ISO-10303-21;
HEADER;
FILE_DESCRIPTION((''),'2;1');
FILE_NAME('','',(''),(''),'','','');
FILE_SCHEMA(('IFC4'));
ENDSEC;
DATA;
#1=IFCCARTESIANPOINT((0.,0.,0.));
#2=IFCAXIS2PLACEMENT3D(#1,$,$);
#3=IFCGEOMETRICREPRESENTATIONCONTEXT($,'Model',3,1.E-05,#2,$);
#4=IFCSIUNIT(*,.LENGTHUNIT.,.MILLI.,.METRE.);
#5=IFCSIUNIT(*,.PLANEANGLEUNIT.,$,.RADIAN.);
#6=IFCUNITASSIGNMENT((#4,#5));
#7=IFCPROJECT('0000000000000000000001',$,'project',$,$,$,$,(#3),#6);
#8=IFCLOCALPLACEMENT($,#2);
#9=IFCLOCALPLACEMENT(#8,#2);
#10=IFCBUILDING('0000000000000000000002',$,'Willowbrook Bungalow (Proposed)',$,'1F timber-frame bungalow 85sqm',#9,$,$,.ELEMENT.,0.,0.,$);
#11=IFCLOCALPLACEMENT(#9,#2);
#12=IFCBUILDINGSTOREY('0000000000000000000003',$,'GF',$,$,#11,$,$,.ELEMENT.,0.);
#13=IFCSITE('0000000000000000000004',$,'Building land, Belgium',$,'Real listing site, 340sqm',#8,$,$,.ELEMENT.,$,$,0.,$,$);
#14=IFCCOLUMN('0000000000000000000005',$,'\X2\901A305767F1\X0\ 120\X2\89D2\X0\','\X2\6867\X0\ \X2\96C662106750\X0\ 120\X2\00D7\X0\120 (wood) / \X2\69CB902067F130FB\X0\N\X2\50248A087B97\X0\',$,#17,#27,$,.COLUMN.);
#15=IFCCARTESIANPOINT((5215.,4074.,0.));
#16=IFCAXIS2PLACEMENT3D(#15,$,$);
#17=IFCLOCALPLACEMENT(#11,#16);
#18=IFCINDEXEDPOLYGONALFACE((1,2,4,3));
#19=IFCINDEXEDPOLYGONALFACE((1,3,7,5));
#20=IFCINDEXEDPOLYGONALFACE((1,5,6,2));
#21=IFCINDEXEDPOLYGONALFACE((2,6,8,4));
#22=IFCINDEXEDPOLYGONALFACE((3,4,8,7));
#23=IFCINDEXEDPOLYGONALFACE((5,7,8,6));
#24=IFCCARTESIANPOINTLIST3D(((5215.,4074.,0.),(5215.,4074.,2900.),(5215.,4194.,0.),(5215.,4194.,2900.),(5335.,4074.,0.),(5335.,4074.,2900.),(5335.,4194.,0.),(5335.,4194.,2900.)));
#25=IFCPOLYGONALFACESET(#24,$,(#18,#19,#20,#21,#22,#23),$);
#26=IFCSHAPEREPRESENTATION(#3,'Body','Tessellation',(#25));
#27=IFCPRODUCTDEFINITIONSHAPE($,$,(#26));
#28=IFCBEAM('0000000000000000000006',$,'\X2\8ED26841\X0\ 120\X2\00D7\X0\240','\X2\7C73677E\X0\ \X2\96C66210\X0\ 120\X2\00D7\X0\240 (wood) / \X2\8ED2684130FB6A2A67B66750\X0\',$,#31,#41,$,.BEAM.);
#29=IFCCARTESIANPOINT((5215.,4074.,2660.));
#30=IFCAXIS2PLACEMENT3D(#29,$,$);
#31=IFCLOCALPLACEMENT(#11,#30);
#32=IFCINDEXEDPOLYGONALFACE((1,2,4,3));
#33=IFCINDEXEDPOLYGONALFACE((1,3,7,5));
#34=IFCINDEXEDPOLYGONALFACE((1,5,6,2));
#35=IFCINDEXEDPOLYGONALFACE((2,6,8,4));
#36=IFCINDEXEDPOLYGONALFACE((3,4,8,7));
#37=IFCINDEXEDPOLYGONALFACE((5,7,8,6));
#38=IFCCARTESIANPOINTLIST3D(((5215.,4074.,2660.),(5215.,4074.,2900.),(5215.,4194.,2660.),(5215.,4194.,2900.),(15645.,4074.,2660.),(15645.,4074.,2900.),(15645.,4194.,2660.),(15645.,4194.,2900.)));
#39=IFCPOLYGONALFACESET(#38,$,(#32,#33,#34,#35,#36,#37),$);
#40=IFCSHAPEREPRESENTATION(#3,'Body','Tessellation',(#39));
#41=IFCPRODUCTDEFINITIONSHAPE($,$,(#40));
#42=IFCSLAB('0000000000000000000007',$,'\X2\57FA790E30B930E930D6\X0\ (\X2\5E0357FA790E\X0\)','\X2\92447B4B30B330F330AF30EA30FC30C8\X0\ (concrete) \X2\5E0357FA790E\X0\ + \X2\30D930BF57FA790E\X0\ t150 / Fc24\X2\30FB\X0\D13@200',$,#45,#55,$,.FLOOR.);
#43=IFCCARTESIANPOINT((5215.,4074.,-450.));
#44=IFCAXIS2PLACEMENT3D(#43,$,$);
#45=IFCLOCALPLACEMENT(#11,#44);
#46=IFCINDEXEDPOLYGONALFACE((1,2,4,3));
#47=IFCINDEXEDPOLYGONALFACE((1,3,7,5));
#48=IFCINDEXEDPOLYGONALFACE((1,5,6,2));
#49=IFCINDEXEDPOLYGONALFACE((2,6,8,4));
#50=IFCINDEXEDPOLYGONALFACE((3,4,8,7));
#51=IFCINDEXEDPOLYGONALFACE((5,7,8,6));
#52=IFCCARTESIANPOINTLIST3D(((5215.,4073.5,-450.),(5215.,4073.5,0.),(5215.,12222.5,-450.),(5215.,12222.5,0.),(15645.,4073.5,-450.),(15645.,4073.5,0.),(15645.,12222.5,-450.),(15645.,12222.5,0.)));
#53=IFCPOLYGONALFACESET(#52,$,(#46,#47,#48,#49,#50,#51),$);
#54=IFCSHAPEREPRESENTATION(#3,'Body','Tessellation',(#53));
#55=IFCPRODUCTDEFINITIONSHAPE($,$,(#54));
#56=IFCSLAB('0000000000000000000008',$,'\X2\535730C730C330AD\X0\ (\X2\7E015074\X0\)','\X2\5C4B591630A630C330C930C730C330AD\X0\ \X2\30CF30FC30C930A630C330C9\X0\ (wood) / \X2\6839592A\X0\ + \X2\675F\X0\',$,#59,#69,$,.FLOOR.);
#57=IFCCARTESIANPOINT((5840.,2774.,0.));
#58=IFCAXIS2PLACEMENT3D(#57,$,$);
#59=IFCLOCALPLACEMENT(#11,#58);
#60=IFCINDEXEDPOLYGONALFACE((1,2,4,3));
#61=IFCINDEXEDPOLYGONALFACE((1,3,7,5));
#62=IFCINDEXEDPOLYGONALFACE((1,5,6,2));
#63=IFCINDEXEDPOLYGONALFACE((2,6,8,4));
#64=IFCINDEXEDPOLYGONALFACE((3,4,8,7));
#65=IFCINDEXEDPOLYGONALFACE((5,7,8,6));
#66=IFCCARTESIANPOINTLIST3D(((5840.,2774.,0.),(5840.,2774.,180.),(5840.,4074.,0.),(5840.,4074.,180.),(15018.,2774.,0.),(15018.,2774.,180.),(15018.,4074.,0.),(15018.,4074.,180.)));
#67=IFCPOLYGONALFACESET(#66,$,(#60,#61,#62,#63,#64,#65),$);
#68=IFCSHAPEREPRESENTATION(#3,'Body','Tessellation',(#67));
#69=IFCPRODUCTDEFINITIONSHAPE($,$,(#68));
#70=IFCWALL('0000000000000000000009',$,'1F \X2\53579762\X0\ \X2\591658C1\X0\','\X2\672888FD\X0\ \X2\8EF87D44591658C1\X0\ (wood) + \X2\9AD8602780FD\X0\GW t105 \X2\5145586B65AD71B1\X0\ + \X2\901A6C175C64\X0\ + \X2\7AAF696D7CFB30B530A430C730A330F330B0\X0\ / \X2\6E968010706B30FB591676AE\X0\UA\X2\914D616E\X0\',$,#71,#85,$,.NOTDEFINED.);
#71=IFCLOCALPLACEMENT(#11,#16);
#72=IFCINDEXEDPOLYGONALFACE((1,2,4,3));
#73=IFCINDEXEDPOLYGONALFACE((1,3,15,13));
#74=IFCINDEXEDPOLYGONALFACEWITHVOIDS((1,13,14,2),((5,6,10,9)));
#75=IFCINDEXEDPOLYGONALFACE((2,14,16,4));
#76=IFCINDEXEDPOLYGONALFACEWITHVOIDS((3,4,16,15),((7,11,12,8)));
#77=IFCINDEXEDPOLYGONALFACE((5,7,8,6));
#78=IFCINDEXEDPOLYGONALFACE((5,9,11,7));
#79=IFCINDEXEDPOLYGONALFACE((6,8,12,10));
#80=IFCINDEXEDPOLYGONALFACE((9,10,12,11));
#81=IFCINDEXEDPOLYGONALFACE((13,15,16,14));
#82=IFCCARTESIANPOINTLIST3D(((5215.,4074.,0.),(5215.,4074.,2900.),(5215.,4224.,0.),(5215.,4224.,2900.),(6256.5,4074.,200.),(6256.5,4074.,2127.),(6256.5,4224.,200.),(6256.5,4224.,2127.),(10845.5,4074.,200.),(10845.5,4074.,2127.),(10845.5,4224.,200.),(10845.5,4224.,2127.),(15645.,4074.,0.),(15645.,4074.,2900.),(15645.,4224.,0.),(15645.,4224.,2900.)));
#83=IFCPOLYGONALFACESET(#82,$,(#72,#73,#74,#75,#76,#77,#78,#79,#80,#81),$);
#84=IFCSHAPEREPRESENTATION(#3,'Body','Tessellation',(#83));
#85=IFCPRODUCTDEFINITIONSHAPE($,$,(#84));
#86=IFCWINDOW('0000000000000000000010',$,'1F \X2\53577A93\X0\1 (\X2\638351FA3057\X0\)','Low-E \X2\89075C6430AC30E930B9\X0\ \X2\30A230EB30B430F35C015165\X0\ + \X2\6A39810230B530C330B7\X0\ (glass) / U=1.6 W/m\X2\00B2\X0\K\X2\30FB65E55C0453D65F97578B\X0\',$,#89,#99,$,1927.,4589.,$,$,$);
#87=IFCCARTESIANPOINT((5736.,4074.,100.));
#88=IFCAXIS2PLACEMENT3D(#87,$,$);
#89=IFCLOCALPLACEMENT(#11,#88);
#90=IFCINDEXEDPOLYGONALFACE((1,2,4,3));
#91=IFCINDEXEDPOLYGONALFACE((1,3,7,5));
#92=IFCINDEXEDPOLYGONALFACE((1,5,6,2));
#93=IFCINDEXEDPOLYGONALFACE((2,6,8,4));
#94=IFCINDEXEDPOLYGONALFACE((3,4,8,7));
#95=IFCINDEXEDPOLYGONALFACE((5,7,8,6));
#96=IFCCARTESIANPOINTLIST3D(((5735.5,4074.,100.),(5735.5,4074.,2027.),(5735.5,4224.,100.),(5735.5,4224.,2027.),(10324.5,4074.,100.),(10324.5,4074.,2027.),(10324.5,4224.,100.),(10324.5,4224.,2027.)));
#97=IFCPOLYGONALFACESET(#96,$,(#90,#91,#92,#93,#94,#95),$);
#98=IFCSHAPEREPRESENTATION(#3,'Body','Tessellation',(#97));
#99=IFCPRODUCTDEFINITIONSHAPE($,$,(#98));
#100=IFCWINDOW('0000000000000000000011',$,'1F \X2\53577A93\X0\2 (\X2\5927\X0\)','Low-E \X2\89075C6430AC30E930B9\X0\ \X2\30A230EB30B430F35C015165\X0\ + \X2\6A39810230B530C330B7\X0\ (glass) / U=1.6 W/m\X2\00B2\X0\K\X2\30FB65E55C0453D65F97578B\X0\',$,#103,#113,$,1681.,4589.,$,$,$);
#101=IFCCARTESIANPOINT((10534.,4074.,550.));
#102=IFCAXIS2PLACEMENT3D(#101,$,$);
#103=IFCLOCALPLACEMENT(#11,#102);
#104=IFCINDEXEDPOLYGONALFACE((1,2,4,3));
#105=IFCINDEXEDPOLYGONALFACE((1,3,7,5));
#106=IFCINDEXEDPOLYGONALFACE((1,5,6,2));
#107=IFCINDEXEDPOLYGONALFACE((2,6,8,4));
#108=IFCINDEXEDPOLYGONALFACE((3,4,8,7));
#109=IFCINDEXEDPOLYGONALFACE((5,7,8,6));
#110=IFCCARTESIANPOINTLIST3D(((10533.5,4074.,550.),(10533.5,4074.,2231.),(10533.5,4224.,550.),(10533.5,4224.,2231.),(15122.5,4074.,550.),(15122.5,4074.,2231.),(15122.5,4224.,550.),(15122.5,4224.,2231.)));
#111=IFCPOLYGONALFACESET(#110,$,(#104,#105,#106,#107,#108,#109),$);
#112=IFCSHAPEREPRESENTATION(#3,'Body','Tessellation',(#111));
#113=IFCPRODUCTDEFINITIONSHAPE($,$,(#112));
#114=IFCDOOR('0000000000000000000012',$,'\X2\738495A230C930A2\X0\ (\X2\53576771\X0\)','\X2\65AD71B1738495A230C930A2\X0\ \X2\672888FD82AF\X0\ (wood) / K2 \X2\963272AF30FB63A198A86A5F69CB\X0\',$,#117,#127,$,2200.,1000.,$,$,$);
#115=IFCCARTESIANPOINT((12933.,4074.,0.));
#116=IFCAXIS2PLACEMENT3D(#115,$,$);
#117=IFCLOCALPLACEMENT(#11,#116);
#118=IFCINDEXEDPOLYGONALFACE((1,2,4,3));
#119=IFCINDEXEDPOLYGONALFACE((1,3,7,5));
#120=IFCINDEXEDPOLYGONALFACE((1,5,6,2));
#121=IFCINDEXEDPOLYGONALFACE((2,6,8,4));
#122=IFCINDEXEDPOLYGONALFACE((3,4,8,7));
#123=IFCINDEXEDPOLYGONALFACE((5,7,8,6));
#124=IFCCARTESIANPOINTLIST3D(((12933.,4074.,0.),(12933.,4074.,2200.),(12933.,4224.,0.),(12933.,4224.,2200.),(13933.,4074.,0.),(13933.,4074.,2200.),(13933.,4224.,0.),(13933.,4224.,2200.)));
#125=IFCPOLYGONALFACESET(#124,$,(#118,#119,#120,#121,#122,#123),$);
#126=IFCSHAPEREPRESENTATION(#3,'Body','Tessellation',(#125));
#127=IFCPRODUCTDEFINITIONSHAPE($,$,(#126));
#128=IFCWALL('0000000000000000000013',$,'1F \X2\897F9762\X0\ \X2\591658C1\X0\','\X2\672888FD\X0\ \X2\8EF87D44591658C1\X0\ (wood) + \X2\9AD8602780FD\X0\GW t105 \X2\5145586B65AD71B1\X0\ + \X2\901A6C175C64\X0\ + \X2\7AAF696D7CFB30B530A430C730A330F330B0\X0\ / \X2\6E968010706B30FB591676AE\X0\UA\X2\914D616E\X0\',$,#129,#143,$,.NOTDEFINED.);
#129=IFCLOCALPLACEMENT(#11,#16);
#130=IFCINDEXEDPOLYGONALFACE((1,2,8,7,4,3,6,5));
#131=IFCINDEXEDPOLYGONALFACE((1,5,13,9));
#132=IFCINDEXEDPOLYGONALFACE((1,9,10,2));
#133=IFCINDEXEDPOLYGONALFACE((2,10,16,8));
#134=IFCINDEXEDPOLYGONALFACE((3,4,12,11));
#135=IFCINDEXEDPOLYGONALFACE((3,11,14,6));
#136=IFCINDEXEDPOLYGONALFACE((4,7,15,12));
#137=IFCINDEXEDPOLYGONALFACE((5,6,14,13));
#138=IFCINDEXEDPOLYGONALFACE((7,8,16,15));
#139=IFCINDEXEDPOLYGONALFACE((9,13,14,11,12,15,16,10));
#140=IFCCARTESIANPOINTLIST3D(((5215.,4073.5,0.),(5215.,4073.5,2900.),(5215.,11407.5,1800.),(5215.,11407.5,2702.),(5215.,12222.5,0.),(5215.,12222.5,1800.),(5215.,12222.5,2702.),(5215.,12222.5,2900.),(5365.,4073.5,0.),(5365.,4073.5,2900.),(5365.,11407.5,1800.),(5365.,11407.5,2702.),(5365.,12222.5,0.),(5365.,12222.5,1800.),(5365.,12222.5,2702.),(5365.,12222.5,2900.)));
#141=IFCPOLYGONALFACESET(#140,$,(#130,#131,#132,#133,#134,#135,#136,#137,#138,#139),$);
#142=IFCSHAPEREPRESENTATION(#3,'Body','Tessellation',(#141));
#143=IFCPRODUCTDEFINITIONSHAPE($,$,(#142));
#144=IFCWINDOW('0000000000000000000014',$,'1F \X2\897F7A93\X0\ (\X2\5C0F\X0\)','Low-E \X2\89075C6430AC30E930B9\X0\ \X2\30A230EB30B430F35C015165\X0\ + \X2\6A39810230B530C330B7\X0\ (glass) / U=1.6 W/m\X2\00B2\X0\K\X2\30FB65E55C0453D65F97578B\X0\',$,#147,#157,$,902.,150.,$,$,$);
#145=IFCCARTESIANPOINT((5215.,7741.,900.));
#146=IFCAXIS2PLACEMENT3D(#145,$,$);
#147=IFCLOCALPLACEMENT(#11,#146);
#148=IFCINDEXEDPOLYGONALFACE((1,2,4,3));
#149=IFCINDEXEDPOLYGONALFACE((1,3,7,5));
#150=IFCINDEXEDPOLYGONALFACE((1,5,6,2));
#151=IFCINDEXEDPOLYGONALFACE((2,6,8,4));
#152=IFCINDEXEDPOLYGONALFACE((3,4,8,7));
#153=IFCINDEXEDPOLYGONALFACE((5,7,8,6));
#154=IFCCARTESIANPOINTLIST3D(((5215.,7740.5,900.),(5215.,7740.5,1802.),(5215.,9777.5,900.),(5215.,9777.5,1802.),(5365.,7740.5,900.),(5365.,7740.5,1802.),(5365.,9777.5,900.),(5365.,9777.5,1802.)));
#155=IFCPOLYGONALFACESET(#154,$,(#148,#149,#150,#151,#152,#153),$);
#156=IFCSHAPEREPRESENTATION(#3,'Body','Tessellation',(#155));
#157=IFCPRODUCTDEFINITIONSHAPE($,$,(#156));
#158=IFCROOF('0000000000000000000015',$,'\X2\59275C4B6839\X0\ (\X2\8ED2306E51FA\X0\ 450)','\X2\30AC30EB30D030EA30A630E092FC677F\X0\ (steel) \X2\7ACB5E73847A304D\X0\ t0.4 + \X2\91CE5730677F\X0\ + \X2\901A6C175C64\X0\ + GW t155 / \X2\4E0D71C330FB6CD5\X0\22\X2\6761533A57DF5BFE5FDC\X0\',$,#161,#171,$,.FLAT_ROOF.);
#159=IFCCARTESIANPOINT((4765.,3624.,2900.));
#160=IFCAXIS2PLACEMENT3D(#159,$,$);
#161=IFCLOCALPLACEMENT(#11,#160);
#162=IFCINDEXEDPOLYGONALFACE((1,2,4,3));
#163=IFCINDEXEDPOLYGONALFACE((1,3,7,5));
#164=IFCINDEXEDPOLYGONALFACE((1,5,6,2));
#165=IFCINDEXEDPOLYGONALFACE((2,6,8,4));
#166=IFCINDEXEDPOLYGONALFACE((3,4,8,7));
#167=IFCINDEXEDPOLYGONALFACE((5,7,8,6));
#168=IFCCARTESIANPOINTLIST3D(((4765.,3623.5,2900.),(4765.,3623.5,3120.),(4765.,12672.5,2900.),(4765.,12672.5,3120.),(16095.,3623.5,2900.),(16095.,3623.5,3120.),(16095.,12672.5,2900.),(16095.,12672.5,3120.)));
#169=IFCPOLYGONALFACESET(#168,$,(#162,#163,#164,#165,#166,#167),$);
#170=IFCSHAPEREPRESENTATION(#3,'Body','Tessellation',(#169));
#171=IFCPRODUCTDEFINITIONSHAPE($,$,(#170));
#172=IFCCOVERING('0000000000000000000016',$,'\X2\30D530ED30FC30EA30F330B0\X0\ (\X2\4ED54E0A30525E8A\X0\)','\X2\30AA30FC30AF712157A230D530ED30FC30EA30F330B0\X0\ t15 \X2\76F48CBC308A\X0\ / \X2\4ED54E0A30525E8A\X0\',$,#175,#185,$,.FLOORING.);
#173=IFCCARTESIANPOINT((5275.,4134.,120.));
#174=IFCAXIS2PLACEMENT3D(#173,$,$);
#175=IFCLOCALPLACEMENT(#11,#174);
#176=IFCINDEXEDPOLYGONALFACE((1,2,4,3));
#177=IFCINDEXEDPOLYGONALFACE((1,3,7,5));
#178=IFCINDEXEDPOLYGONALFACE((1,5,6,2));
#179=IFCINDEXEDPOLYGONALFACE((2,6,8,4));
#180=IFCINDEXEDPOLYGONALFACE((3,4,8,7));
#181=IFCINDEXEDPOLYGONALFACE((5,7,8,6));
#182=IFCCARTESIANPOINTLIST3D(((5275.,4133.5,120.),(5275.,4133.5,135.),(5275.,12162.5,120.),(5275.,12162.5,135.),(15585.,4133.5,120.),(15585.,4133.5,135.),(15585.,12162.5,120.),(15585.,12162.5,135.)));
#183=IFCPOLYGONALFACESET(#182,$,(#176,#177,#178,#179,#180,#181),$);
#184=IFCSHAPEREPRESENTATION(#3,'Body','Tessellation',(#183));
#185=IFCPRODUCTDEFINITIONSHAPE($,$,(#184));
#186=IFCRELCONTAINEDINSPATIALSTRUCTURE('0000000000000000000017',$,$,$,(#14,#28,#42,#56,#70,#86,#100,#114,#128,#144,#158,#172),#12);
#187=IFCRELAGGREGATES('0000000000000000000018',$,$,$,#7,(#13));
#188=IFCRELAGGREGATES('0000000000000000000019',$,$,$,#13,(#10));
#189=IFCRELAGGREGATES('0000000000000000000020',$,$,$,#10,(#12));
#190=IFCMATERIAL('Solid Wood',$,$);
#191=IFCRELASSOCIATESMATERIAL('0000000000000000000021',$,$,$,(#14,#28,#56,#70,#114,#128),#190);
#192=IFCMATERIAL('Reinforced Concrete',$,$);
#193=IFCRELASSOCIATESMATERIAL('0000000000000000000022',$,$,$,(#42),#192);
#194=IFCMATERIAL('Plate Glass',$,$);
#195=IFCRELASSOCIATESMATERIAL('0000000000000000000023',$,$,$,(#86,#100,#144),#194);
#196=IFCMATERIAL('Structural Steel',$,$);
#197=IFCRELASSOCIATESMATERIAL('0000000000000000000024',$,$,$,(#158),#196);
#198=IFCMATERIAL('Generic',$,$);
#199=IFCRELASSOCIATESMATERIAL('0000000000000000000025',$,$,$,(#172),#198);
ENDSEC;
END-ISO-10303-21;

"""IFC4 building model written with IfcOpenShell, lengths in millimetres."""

from ifc_helpers import new_model, si_unit, frame, frame_2d, origin, place, context, project, spatial, rectangle, extrude, material, element, fill, save


model = new_model("IFC4")

# Units and contexts
model_context = context("Model", 3, precision=1e-05, world=origin())
ifc_project = project(units=[si_unit("LENGTHUNIT", "METRE", prefix="MILLI"), si_unit("PLANEANGLEUNIT", "RADIAN")], contexts=[model_context])

# Site, building, storey
site_placement = place(None, origin())
site = spatial("IfcSite", under=ifc_project, at=site_placement, Name="Building land, Belgium", ObjectType="Real listing site, 340sqm", CompositionType="ELEMENT", RefElevation=0.0)
building_placement = place(site_placement, origin())
building = spatial("IfcBuilding", under=site, at=building_placement, Name="Willowbrook Bungalow (Proposed)", ObjectType="1F timber-frame bungalow 85sqm", CompositionType="ELEMENT", ElevationOfRefHeight=0.0, ElevationOfTerrain=0.0)
storey_placement = place(building_placement, origin())
storey = spatial("IfcBuildingStorey", under=building, at=storey_placement, Name="GF", CompositionType="ELEMENT", Elevation=0.0)

# Column
ifc_material_1 = material(Name="Solid Wood")
column_1_placement = place(storey_placement, frame((5215.0, 4074.0, 0.0)))
element("IfcColumn", 1, at=column_1_placement, inside=storey, material=ifc_material_1, Name="通し柱 120角", Description="桧 集成材 120×120 (wood) / 構造柱・N値計算", PredefinedType="COLUMN", context=model_context, shape_type="SweptSolid", body=[
    extrude(rectangle(XDim=120.0, YDim=120.0, at=frame_2d((60.0, 60.0))), frame((5215.0, 4074.0, 0.0)), (0.0, 0.0, 1.0), 2900.0),
])

# Beam
beam_1_placement = place(storey_placement, frame((5215.0, 4074.0, 2660.0)))
element("IfcBeam", 2, at=beam_1_placement, inside=storey, material=ifc_material_1, Name="軒桁 120×240", Description="米松 集成 120×240 (wood) / 軒桁・横架材", PredefinedType="BEAM", context=model_context, shape_type="SweptSolid", body=[
    extrude(rectangle(XDim=10430.0, YDim=120.0, at=frame_2d((5215.0, 60.0))), frame((5215.0, 4074.0, 2660.0)), (0.0, 0.0, 1.0), 240.0),
])

# Slabs
ifc_material_2 = material(Name="Reinforced Concrete")
slab_1_placement = place(storey_placement, frame((5215.0, 4074.0, -450.0)))
element("IfcSlab", 3, at=slab_1_placement, inside=storey, material=ifc_material_2, Name="基礎スラブ (布基礎)", Description="鉄筋コンクリート (concrete) 布基礎 + ベタ基礎 t150 / Fc24・D13@200", PredefinedType="FLOOR", context=model_context, shape_type="SweptSolid", body=[
    extrude(rectangle(XDim=10430.0, YDim=8149.0, at=frame_2d((5215.0, 4074.0))), frame((5215.0, 4074.0, -450.0)), (0.0, 0.0, 1.0), 450.0),
])
slab_2_placement = place(storey_placement, frame((5840.0, 2774.0, 0.0)))
element("IfcSlab", 4, at=slab_2_placement, inside=storey, material=ifc_material_1, Name="南デッキ (縁側)", Description="屋外ウッドデッキ ハードウッド (wood) / 根太 + 束", PredefinedType="FLOOR", context=model_context, shape_type="SweptSolid", body=[
    extrude(rectangle(XDim=9178.0, YDim=1300.0, at=frame_2d((4589.0, 650.0))), frame((5840.0, 2774.0, 0.0)), (0.0, 0.0, 1.0), 180.0),
])

# Wall, openings, windows, door
wall_1_placement = place(storey_placement, frame((5215.0, 4074.0, 0.0)))
wall_1 = element("IfcWall", 5, at=wall_1_placement, inside=storey, material=ifc_material_1, Name="1F 南面 外壁", Description="木製 軸組外壁 (wood) + 高性能GW t105 充填断熱 + 通気層 + 窯業系サイディング / 準耐火・外皮UA配慮", PredefinedType="NOTDEFINED", context=model_context, shape_type="SweptSolid", body=[
    extrude(rectangle(XDim=10430.0, YDim=150.0, at=frame_2d((5215.0, 75.0))), frame((5215.0, 4074.0, 0.0)), (0.0, 0.0, 1.0), 2900.0),
])
opening_1_placement = place(storey_placement, frame((5736.0, 4074.0, 100.0)))
opening_1 = element("IfcOpeningElement", 6, at=opening_1_placement, cuts=wall_1, PredefinedType="NOTDEFINED", context=model_context, shape_type="SweptSolid", body=[
    extrude(rectangle(XDim=4589.0, YDim=150.0, at=frame_2d((2294.0, 75.0))), frame((5736.0, 4074.0, 100.0)), (0.0, 0.0, 1.0), 1927.0),
])
opening_2_placement = place(storey_placement, frame((10534.0, 4074.0, 550.0)))
opening_2 = element("IfcOpeningElement", 7, at=opening_2_placement, cuts=wall_1, PredefinedType="NOTDEFINED", context=model_context, shape_type="SweptSolid", body=[
    extrude(rectangle(XDim=4589.0, YDim=150.0, at=frame_2d((2294.0, 75.0))), frame((10534.0, 4074.0, 550.0)), (0.0, 0.0, 1.0), 1681.0),
])
opening_3_placement = place(storey_placement, frame((12933.0, 4074.0, 0.0)))
opening_3 = element("IfcOpeningElement", 8, at=opening_3_placement, cuts=wall_1, PredefinedType="NOTDEFINED", context=model_context, shape_type="SweptSolid", body=[
    extrude(rectangle(XDim=1000.0, YDim=150.0, at=frame_2d((500.0, 75.0))), frame((12933.0, 4074.0, 0.0)), (0.0, 0.0, 1.0), 2200.0),
])
ifc_material_3 = material(Name="Plate Glass")
window_1_placement = place(storey_placement, frame((5736.0, 4074.0, 100.0)))
window_1 = element("IfcWindow", 9, at=window_1_placement, inside=storey, material=ifc_material_3, Name="1F 南窓1 (掃出し)", Description="Low-E 複層ガラス アルゴン封入 + 樹脂サッシ (glass) / U=1.6 W/m²K・日射取得型", OverallHeight=1927.0, OverallWidth=4589.0, context=model_context, shape_type="SweptSolid", body=[
    extrude(rectangle(XDim=4589.0, YDim=150.0, at=frame_2d((2294.0, 75.0))), frame((5736.0, 4074.0, 100.0)), (0.0, 0.0, 1.0), 1927.0),
])
fill(opening_1, window_1)
window_2_placement = place(storey_placement, frame((10534.0, 4074.0, 550.0)))
window_2 = element("IfcWindow", 10, at=window_2_placement, inside=storey, material=ifc_material_3, Name="1F 南窓2 (大)", Description="Low-E 複層ガラス アルゴン封入 + 樹脂サッシ (glass) / U=1.6 W/m²K・日射取得型", OverallHeight=1681.0, OverallWidth=4589.0, context=model_context, shape_type="SweptSolid", body=[
    extrude(rectangle(XDim=4589.0, YDim=150.0, at=frame_2d((2294.0, 75.0))), frame((10534.0, 4074.0, 550.0)), (0.0, 0.0, 1.0), 1681.0),
])
fill(opening_2, window_2)
door_placement = place(storey_placement, frame((12933.0, 4074.0, 0.0)))
door = element("IfcDoor", 11, at=door_placement, inside=storey, material=ifc_material_1, Name="玄関ドア (南東)", Description="断熱玄関ドア 木製芯 (wood) / K2 防犯・採風機構", OverallHeight=2200.0, OverallWidth=1000.0, context=model_context, shape_type="SweptSolid", body=[
    extrude(rectangle(XDim=1000.0, YDim=150.0, at=frame_2d((500.0, 75.0))), frame((12933.0, 4074.0, 0.0)), (0.0, 0.0, 1.0), 2200.0),
])
fill(opening_3, door)

# Wall, opening, window
wall_2_placement = place(storey_placement, frame((5215.0, 4074.0, 0.0)))
wall_2 = element("IfcWall", 12, at=wall_2_placement, inside=storey, material=ifc_material_1, Name="1F 西面 外壁", Description="木製 軸組外壁 (wood) + 高性能GW t105 充填断熱 + 通気層 + 窯業系サイディング / 準耐火・外皮UA配慮", PredefinedType="NOTDEFINED", context=model_context, shape_type="SweptSolid", body=[
    extrude(rectangle(XDim=150.0, YDim=8149.0, at=frame_2d((75.0, 4074.0))), frame((5215.0, 4074.0, 0.0)), (0.0, 0.0, 1.0), 2900.0),
])
opening_4_placement = place(storey_placement, frame((5215.0, 7741.0, 900.0)))
opening_4 = element("IfcOpeningElement", 13, at=opening_4_placement, cuts=wall_2, PredefinedType="NOTDEFINED", context=model_context, shape_type="SweptSolid", body=[
    extrude(rectangle(XDim=150.0, YDim=2037.0, at=frame_2d((75.0, 1018.0))), frame((5215.0, 7741.0, 900.0)), (0.0, 0.0, 1.0), 902.0),
])
window_3_placement = place(storey_placement, frame((5215.0, 7741.0, 900.0)))
window_3 = element("IfcWindow", 14, at=window_3_placement, inside=storey, material=ifc_material_3, Name="1F 西窓 (小)", Description="Low-E 複層ガラス アルゴン封入 + 樹脂サッシ (glass) / U=1.6 W/m²K・日射取得型", OverallHeight=902.0, OverallWidth=150.0, context=model_context, shape_type="SweptSolid", body=[
    extrude(rectangle(XDim=150.0, YDim=2037.0, at=frame_2d((75.0, 1018.0))), frame((5215.0, 7741.0, 900.0)), (0.0, 0.0, 1.0), 902.0),
])
fill(opening_4, window_3)

# Roof
ifc_material_4 = material(Name="Structural Steel")
roof_placement = place(storey_placement, frame((4765.0, 3624.0, 2900.0)))
element("IfcRoof", 15, at=roof_placement, inside=storey, material=ifc_material_4, Name="大屋根 (軒の出 450)", Description="ガルバリウム鋼板 (steel) 立平葺き t0.4 + 野地板 + 通気層 + GW t155 / 不燃・法22条区域対応", PredefinedType="FLAT_ROOF", context=model_context, shape_type="SweptSolid", body=[
    extrude(rectangle(XDim=11330.0, YDim=9049.0, at=frame_2d((5665.0, 4524.0))), frame((4765.0, 3624.0, 2900.0)), (0.0, 0.0, 1.0), 220.0),
])

# Covering
ifc_material_5 = material(Name="Generic")
covering_1_placement = place(storey_placement, frame((5275.0, 4134.0, 120.0)))
element("IfcCovering", 16, at=covering_1_placement, inside=storey, material=ifc_material_5, Name="フローリング (仕上げ床)", Description="オーク無垢フローリング t15 直貼り / 仕上げ床", PredefinedType="FLOORING", context=model_context, shape_type="SweptSolid", body=[
    extrude(rectangle(XDim=10310.0, YDim=8029.0, at=frame_2d((5155.0, 4014.0))), frame((5275.0, 4134.0, 120.0)), (0.0, 0.0, 1.0), 15.0),
])

save(model, "model.ifc")
